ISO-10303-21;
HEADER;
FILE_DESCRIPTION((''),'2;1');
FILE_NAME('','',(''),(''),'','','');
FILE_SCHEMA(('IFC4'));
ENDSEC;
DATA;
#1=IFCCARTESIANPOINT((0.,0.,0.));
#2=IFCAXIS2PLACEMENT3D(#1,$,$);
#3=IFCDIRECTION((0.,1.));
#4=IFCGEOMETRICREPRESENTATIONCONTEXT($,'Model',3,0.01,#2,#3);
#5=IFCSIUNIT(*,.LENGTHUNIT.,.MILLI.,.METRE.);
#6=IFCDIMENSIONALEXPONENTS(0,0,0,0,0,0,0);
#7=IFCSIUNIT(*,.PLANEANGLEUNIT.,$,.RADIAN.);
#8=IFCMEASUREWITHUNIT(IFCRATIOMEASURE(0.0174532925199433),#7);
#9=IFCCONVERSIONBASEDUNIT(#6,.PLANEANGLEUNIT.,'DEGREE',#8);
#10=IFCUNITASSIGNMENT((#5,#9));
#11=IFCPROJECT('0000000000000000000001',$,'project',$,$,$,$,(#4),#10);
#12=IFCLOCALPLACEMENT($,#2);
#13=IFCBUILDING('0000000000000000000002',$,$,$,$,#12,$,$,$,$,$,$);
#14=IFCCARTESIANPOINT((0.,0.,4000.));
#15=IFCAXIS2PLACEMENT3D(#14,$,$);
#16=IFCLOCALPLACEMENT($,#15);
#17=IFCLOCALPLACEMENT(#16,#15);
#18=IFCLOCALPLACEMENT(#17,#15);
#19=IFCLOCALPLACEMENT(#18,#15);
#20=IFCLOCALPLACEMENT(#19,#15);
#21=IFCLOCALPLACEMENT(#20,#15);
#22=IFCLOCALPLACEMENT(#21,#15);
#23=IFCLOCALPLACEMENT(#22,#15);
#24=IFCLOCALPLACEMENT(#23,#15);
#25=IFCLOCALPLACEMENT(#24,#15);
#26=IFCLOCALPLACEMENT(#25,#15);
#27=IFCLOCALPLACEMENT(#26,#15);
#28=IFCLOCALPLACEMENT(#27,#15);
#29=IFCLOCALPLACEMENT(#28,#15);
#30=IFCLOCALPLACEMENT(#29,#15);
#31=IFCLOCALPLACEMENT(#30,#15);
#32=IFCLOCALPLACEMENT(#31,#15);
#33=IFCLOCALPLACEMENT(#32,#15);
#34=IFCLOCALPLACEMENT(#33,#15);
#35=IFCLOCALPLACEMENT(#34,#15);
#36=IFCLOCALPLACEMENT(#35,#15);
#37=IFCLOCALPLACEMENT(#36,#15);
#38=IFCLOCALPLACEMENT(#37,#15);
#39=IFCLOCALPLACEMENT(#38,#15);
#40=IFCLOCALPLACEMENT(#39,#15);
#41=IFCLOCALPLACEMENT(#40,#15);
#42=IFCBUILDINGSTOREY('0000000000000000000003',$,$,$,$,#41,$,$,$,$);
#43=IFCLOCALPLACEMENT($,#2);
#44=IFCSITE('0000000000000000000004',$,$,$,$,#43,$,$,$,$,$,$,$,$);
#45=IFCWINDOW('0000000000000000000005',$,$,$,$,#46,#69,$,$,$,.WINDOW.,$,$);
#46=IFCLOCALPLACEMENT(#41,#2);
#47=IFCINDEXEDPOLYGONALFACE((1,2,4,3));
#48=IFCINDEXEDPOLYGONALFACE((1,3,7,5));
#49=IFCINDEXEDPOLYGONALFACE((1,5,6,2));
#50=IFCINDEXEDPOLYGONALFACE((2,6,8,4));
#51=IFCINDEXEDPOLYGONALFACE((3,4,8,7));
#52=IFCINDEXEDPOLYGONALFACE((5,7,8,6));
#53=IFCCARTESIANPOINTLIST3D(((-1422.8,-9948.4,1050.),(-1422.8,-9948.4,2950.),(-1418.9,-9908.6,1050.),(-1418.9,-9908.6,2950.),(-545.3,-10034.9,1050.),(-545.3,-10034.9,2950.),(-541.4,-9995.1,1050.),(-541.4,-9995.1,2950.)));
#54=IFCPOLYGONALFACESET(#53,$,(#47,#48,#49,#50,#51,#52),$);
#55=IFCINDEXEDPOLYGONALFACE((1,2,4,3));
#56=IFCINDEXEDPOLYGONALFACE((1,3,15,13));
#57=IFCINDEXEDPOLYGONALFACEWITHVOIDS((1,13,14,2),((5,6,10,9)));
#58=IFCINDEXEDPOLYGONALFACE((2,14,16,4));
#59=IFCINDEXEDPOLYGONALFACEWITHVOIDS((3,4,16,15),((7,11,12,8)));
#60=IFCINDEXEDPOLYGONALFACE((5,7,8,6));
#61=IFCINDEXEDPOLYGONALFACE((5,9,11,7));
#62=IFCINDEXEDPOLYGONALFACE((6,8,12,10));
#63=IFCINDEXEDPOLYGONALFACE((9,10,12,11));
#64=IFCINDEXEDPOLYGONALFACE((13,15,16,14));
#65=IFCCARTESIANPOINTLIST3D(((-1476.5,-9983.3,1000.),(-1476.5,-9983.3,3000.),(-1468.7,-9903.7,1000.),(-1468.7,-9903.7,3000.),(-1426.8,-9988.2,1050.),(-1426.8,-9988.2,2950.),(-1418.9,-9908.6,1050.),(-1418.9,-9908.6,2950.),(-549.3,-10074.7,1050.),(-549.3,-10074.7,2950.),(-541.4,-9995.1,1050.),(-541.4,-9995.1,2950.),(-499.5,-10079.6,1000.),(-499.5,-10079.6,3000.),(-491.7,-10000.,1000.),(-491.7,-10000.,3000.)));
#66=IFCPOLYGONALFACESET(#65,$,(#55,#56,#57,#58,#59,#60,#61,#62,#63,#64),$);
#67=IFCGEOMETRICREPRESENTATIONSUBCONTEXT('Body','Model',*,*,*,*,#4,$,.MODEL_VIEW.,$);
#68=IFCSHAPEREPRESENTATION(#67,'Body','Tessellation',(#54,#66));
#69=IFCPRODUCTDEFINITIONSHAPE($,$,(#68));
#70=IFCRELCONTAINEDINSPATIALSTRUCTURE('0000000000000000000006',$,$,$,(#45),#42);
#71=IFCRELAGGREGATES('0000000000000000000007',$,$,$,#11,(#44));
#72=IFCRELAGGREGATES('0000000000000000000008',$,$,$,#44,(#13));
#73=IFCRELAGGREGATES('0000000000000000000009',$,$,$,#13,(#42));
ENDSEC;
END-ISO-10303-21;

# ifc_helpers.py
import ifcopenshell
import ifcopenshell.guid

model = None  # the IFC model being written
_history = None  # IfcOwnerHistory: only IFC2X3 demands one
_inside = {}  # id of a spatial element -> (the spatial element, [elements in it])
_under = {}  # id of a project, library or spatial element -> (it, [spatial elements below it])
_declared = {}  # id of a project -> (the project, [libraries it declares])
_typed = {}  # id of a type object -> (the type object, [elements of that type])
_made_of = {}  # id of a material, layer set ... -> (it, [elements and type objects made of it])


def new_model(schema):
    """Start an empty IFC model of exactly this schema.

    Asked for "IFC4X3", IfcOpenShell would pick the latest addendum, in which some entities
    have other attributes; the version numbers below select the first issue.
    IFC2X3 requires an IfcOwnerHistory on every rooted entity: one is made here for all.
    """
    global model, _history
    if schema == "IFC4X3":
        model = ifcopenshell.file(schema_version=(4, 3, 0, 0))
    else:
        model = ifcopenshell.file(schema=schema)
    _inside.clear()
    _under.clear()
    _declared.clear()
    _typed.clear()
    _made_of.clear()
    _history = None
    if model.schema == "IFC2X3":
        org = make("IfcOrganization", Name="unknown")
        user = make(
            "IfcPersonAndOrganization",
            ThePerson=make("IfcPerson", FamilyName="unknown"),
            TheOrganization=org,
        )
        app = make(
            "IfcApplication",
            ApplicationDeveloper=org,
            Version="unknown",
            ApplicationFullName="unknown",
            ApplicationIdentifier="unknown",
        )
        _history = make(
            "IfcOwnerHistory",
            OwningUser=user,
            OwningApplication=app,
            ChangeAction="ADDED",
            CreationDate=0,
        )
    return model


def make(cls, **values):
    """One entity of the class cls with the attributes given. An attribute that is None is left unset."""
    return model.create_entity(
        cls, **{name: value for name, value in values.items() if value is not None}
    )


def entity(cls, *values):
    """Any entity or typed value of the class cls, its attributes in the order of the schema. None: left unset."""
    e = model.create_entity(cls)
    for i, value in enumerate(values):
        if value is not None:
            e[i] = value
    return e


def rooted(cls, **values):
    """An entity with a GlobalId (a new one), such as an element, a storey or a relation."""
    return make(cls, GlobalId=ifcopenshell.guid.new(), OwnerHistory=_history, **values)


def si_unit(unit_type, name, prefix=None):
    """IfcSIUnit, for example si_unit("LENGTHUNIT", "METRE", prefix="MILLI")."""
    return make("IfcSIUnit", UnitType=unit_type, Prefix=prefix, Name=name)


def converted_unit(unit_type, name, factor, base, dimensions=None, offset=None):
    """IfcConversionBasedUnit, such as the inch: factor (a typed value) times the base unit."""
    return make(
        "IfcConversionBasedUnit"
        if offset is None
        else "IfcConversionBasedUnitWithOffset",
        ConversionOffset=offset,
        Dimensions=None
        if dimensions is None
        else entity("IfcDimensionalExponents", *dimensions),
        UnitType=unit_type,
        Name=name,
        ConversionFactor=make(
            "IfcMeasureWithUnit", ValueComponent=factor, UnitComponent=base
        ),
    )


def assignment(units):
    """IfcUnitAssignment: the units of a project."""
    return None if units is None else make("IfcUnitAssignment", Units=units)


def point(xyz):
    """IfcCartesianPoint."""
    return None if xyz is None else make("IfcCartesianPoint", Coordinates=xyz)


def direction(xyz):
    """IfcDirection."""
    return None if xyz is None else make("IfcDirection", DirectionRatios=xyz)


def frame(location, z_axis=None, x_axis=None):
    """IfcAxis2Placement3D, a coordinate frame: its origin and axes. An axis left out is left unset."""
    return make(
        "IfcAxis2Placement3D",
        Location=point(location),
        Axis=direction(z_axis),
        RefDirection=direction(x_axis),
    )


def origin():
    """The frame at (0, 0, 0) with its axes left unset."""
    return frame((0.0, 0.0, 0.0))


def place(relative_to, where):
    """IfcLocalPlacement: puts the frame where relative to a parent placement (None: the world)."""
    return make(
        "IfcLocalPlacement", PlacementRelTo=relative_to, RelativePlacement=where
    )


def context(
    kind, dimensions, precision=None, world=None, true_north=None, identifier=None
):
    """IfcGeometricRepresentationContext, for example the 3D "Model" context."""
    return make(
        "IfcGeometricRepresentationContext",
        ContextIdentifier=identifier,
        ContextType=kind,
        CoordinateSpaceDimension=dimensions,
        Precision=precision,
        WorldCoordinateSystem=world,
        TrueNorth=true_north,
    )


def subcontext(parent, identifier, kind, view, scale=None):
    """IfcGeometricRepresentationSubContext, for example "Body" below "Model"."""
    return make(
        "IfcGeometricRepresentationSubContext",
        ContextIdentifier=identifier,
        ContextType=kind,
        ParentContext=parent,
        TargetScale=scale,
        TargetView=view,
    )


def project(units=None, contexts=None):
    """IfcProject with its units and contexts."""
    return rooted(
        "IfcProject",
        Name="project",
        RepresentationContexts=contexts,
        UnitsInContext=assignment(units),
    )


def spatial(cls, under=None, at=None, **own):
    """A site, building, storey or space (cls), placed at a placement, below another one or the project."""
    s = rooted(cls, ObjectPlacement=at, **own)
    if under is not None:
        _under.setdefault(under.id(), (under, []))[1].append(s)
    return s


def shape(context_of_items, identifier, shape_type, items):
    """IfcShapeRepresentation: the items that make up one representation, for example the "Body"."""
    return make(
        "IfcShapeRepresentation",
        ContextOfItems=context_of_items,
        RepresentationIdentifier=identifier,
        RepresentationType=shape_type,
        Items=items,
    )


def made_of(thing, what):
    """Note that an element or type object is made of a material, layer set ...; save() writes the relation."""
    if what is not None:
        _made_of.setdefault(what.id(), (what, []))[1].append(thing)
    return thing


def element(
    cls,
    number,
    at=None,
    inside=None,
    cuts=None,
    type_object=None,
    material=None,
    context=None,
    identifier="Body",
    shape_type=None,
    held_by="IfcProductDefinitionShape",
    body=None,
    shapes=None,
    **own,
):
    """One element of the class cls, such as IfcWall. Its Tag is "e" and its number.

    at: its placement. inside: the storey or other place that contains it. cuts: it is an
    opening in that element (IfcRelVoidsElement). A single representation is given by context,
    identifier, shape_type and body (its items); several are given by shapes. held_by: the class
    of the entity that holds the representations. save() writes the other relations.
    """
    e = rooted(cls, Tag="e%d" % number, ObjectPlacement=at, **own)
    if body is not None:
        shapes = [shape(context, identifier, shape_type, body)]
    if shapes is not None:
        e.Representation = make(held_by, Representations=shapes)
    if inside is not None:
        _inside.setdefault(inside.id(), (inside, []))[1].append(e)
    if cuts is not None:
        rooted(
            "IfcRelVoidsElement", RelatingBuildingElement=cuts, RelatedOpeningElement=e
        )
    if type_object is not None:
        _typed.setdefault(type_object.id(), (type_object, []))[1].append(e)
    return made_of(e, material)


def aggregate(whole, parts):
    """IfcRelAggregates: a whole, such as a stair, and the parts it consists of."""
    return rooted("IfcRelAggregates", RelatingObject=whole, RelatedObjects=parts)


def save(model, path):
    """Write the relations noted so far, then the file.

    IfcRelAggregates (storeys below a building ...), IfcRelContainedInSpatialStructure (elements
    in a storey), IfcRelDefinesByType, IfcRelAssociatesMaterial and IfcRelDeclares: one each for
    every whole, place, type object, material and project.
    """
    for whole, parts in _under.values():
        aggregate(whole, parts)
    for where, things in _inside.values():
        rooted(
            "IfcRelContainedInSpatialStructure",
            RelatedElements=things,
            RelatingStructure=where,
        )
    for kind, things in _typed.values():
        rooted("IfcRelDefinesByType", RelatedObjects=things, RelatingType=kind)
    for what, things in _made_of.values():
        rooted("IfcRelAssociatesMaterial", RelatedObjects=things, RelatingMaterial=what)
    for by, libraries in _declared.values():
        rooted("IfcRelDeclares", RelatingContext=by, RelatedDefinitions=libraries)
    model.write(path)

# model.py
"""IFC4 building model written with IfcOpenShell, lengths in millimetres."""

from ifc_helpers import new_model, entity, si_unit, converted_unit, direction, frame, origin, place, context, subcontext, project, spatial, element, save


model = new_model("IFC4")

# Units and contexts
model_context = context("Model", 3, precision=0.01, world=origin(), true_north=direction((0.0, 1.0)))
body_context = subcontext(model_context, "Body", "Model", "MODEL_VIEW")
ifc_project = project(units=[si_unit("LENGTHUNIT", "METRE", prefix="MILLI"), converted_unit("PLANEANGLEUNIT", "DEGREE", entity("IfcRatioMeasure", 0.0174532925199433), si_unit("PLANEANGLEUNIT", "RADIAN"), dimensions=[0, 0, 0, 0, 0, 0, 0])], contexts=[model_context])

# Site, building, storey
site_placement = place(None, origin())
site = spatial("IfcSite", under=ifc_project, at=site_placement)
building_placement = place(None, origin())
building = spatial("IfcBuilding", under=site, at=building_placement)
placement_1 = place(None, frame((0.0, 0.0, 4000.0)))
placement_2 = place(placement_1, frame((0.0, 0.0, 4000.0)))
placement_3 = place(placement_2, frame((0.0, 0.0, 4000.0)))
placement_4 = place(placement_3, frame((0.0, 0.0, 4000.0)))
placement_5 = place(placement_4, frame((0.0, 0.0, 4000.0)))
placement_6 = place(placement_5, frame((0.0, 0.0, 4000.0)))
placement_7 = place(placement_6, frame((0.0, 0.0, 4000.0)))
placement_8 = place(placement_7, frame((0.0, 0.0, 4000.0)))
placement_9 = place(placement_8, frame((0.0, 0.0, 4000.0)))
placement_10 = place(placement_9, frame((0.0, 0.0, 4000.0)))
placement_11 = place(placement_10, frame((0.0, 0.0, 4000.0)))
placement_12 = place(placement_11, frame((0.0, 0.0, 4000.0)))
placement_13 = place(placement_12, frame((0.0, 0.0, 4000.0)))
placement_14 = place(placement_13, frame((0.0, 0.0, 4000.0)))
placement_15 = place(placement_14, frame((0.0, 0.0, 4000.0)))
placement_16 = place(placement_15, frame((0.0, 0.0, 4000.0)))
placement_17 = place(placement_16, frame((0.0, 0.0, 4000.0)))
placement_18 = place(placement_17, frame((0.0, 0.0, 4000.0)))
placement_19 = place(placement_18, frame((0.0, 0.0, 4000.0)))
placement_20 = place(placement_19, frame((0.0, 0.0, 4000.0)))
placement_21 = place(placement_20, frame((0.0, 0.0, 4000.0)))
placement_22 = place(placement_21, frame((0.0, 0.0, 4000.0)))
placement_23 = place(placement_22, frame((0.0, 0.0, 4000.0)))
placement_24 = place(placement_23, frame((0.0, 0.0, 4000.0)))
placement_25 = place(placement_24, frame((0.0, 0.0, 4000.0)))
storey_placement = place(placement_25, frame((0.0, 0.0, 4000.0)))
storey = spatial("IfcBuildingStorey", under=building, at=storey_placement)

# Shared definitions
cartesian_point_1 = entity("IfcCartesianPoint", [-440.9, -950.0])
shared_polyline = entity("IfcPolyline", [cartesian_point_1, entity("IfcCartesianPoint", [-440.9, 950.0]), entity("IfcCartesianPoint", [-440.9, 950.0]), entity("IfcCartesianPoint", [440.9, 950.0]), entity("IfcCartesianPoint", [440.9, 950.0]), entity("IfcCartesianPoint", [440.9, -950.0]), entity("IfcCartesianPoint", [440.9, -950.0]), entity("IfcCartesianPoint", [-440.9, -950.0]), cartesian_point_1])

# Window
window_1_placement = place(storey_placement, frame((-980.2, -9951.8, 2000.0), z_axis=(0.0, 0.0, 1.0), x_axis=(9951.847473, -980.16931, 0.0)))
cartesian_point_2 = entity("IfcCartesianPoint", [-490.9, -1000.0])
element("IfcWindow", 1, at=window_1_placement, inside=storey, PredefinedType="WINDOW", context=body_context, shape_type="SweptSolid", body=[
    entity("IfcExtrudedAreaSolid", entity("IfcArbitraryClosedProfileDef", "AREA", None, shared_polyline), entity("IfcAxis2Placement3D", entity("IfcCartesianPoint", [0.0, 0.0, 0.0]), entity("IfcDirection", [0.0, -1.0, 0.0]), entity("IfcDirection", [1.0, 0.0, 0.0])), entity("IfcDirection", [0.0, 0.0, 1.0]), 40.0),
    entity("IfcExtrudedAreaSolid", entity("IfcArbitraryProfileDefWithVoids", "AREA", None, entity("IfcPolyline", [cartesian_point_2, entity("IfcCartesianPoint", [-490.9, 1000.0]), entity("IfcCartesianPoint", [-490.9, 1000.0]), entity("IfcCartesianPoint", [490.9, 1000.0]), entity("IfcCartesianPoint", [490.9, 1000.0]), entity("IfcCartesianPoint", [490.9, -1000.0]), entity("IfcCartesianPoint", [490.9, -1000.0]), entity("IfcCartesianPoint", [-490.9, -1000.0]), cartesian_point_2]), [shared_polyline]), entity("IfcAxis2Placement3D", entity("IfcCartesianPoint", [0.0, 0.0, 0.0]), entity("IfcDirection", [0.0, -1.0, 0.0]), entity("IfcDirection", [1.0, 0.0, 0.0])), entity("IfcDirection", [0.0, 0.0, 1.0]), 80.0),
])

save(model, "model.ifc")
